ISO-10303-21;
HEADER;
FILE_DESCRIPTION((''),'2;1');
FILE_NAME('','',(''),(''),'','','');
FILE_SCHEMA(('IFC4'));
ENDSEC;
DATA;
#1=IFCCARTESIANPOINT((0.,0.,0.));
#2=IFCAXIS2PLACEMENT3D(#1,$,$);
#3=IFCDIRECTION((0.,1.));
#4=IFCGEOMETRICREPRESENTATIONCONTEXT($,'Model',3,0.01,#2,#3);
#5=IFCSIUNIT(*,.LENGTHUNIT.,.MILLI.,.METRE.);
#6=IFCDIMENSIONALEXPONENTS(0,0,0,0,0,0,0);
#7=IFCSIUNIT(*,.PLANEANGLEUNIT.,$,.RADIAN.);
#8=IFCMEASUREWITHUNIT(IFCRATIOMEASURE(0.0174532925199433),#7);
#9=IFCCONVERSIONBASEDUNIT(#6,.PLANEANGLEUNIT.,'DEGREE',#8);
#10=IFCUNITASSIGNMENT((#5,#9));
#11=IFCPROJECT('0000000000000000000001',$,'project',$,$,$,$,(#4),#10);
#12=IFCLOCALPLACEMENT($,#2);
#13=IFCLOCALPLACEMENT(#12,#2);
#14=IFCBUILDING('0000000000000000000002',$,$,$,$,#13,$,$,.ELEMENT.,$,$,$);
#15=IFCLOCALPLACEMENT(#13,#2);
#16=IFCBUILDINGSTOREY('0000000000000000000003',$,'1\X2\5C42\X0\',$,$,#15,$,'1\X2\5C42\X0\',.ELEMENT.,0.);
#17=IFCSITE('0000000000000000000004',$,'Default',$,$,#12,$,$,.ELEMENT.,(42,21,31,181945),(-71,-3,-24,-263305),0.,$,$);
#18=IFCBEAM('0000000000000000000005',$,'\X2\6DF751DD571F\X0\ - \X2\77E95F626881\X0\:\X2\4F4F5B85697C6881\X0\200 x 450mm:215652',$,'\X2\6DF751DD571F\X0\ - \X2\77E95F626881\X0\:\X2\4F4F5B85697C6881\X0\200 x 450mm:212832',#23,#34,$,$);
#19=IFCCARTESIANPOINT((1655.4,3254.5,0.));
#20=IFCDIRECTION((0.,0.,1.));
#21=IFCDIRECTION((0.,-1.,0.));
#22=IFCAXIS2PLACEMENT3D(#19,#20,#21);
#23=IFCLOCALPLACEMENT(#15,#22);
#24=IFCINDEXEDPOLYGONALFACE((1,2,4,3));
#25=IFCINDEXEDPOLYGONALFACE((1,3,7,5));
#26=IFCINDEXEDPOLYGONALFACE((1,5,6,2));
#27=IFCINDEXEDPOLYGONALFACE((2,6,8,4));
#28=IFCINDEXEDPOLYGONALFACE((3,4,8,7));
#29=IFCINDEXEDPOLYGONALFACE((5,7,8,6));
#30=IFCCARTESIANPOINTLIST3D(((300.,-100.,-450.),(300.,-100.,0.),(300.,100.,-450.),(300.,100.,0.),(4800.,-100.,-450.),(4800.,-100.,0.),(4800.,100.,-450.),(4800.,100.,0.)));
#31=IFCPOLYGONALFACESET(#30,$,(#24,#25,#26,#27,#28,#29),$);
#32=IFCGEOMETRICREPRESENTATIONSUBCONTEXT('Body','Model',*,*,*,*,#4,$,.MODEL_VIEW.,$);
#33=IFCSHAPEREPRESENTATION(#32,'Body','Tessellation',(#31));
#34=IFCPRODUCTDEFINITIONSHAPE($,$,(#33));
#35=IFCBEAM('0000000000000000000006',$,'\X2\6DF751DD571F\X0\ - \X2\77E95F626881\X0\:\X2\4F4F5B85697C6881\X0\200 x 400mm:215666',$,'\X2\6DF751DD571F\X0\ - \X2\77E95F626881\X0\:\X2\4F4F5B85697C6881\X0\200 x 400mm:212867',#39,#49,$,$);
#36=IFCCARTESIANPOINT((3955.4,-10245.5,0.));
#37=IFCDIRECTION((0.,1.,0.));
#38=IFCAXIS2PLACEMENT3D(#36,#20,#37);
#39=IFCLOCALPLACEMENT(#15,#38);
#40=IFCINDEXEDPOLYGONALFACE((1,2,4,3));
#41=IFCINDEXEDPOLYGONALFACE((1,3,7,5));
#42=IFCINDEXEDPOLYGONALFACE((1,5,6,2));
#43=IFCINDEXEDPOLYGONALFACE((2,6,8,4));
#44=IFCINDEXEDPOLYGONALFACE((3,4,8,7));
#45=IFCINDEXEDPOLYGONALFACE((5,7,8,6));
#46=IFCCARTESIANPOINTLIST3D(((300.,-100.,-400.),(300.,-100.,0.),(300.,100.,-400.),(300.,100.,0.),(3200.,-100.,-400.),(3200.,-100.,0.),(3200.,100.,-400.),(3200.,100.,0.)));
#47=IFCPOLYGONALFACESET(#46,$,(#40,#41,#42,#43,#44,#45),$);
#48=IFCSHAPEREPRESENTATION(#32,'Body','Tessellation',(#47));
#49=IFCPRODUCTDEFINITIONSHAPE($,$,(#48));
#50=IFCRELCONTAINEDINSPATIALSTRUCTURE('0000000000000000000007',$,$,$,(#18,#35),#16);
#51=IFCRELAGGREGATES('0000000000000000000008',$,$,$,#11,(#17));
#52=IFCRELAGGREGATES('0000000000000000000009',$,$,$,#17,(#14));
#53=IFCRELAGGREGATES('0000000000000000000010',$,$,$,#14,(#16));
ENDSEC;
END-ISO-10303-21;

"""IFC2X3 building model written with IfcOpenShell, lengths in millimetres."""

from ifc_helpers import new_model, entity, si_unit, converted_unit, direction, frame, frame_2d, origin, place, context, subcontext, project, spatial, rectangle, extrude, element, save


model = new_model("IFC2X3")

# Units and contexts
model_context = context("Model", 3, precision=0.01, world=origin(), true_north=direction((0.0, 1.0)))
body_context = subcontext(model_context, "Body", "Model", "MODEL_VIEW")
ifc_project = project(units=[si_unit("LENGTHUNIT", "METRE", prefix="MILLI"), converted_unit("PLANEANGLEUNIT", "DEGREE", entity("IfcRatioMeasure", 0.0174532925199433), si_unit("PLANEANGLEUNIT", "RADIAN"), dimensions=[0, 0, 0, 0, 0, 0, 0])], contexts=[model_context])

# Site, building, storey
site_placement = place(None, origin())
site = spatial("IfcSite", under=ifc_project, at=site_placement, Name="Default", CompositionType="ELEMENT", RefLatitude=(42, 21, 31, 181945), RefLongitude=(-71, -3, -24, -263305), RefElevation=0.0)
building_placement = place(site_placement, origin())
building = spatial("IfcBuilding", under=site, at=building_placement, CompositionType="ELEMENT")
storey_placement = place(building_placement, origin())
storey = spatial("IfcBuildingStorey", under=building, at=storey_placement, Name="1层", LongName="1层", CompositionType="ELEMENT", Elevation=0.0)

# Beams
beam_1_placement = place(storey_placement, frame((1655.4, 3254.5, 0.0), z_axis=(0.0, 0.0, 1.0), x_axis=(0.0, -1.0, 0.0)))
element("IfcBeam", 1, at=beam_1_placement, inside=storey, Name="混凝土 - 矩形梁:住宅楼梁200 x 450mm:215652", ObjectType="混凝土 - 矩形梁:住宅楼梁200 x 450mm:212832", context=body_context, shape_type="SweptSolid", body=[
    extrude(rectangle(XDim=450.0, YDim=200.0, at=frame_2d((0.0, 0.0), x_axis=(1.0, 0.0))), frame((300.0, 0.0, -225.0), z_axis=(1.0, 0.0, 0.0), x_axis=(0.0, 0.0, -1.0)), (0.0, 0.0, 1.0), 4500.0),
])
beam_2_placement = place(storey_placement, frame((3955.4, -10245.5, 0.0), z_axis=(0.0, 0.0, 1.0), x_axis=(0.0, 1.0, 0.0)))
element("IfcBeam", 2, at=beam_2_placement, inside=storey, Name="混凝土 - 矩形梁:住宅楼梁200 x 400mm:215666", ObjectType="混凝土 - 矩形梁:住宅楼梁200 x 400mm:212867", context=body_context, shape_type="SweptSolid", body=[
    extrude(rectangle(XDim=400.0, YDim=200.0, at=frame_2d((0.0, 0.0), x_axis=(1.0, 0.0))), frame((300.0, 0.0, -200.0), z_axis=(1.0, 0.0, 0.0), x_axis=(0.0, 0.0, -1.0)), (0.0, 0.0, 1.0), 2900.0),
])

save(model, "model.ifc")
